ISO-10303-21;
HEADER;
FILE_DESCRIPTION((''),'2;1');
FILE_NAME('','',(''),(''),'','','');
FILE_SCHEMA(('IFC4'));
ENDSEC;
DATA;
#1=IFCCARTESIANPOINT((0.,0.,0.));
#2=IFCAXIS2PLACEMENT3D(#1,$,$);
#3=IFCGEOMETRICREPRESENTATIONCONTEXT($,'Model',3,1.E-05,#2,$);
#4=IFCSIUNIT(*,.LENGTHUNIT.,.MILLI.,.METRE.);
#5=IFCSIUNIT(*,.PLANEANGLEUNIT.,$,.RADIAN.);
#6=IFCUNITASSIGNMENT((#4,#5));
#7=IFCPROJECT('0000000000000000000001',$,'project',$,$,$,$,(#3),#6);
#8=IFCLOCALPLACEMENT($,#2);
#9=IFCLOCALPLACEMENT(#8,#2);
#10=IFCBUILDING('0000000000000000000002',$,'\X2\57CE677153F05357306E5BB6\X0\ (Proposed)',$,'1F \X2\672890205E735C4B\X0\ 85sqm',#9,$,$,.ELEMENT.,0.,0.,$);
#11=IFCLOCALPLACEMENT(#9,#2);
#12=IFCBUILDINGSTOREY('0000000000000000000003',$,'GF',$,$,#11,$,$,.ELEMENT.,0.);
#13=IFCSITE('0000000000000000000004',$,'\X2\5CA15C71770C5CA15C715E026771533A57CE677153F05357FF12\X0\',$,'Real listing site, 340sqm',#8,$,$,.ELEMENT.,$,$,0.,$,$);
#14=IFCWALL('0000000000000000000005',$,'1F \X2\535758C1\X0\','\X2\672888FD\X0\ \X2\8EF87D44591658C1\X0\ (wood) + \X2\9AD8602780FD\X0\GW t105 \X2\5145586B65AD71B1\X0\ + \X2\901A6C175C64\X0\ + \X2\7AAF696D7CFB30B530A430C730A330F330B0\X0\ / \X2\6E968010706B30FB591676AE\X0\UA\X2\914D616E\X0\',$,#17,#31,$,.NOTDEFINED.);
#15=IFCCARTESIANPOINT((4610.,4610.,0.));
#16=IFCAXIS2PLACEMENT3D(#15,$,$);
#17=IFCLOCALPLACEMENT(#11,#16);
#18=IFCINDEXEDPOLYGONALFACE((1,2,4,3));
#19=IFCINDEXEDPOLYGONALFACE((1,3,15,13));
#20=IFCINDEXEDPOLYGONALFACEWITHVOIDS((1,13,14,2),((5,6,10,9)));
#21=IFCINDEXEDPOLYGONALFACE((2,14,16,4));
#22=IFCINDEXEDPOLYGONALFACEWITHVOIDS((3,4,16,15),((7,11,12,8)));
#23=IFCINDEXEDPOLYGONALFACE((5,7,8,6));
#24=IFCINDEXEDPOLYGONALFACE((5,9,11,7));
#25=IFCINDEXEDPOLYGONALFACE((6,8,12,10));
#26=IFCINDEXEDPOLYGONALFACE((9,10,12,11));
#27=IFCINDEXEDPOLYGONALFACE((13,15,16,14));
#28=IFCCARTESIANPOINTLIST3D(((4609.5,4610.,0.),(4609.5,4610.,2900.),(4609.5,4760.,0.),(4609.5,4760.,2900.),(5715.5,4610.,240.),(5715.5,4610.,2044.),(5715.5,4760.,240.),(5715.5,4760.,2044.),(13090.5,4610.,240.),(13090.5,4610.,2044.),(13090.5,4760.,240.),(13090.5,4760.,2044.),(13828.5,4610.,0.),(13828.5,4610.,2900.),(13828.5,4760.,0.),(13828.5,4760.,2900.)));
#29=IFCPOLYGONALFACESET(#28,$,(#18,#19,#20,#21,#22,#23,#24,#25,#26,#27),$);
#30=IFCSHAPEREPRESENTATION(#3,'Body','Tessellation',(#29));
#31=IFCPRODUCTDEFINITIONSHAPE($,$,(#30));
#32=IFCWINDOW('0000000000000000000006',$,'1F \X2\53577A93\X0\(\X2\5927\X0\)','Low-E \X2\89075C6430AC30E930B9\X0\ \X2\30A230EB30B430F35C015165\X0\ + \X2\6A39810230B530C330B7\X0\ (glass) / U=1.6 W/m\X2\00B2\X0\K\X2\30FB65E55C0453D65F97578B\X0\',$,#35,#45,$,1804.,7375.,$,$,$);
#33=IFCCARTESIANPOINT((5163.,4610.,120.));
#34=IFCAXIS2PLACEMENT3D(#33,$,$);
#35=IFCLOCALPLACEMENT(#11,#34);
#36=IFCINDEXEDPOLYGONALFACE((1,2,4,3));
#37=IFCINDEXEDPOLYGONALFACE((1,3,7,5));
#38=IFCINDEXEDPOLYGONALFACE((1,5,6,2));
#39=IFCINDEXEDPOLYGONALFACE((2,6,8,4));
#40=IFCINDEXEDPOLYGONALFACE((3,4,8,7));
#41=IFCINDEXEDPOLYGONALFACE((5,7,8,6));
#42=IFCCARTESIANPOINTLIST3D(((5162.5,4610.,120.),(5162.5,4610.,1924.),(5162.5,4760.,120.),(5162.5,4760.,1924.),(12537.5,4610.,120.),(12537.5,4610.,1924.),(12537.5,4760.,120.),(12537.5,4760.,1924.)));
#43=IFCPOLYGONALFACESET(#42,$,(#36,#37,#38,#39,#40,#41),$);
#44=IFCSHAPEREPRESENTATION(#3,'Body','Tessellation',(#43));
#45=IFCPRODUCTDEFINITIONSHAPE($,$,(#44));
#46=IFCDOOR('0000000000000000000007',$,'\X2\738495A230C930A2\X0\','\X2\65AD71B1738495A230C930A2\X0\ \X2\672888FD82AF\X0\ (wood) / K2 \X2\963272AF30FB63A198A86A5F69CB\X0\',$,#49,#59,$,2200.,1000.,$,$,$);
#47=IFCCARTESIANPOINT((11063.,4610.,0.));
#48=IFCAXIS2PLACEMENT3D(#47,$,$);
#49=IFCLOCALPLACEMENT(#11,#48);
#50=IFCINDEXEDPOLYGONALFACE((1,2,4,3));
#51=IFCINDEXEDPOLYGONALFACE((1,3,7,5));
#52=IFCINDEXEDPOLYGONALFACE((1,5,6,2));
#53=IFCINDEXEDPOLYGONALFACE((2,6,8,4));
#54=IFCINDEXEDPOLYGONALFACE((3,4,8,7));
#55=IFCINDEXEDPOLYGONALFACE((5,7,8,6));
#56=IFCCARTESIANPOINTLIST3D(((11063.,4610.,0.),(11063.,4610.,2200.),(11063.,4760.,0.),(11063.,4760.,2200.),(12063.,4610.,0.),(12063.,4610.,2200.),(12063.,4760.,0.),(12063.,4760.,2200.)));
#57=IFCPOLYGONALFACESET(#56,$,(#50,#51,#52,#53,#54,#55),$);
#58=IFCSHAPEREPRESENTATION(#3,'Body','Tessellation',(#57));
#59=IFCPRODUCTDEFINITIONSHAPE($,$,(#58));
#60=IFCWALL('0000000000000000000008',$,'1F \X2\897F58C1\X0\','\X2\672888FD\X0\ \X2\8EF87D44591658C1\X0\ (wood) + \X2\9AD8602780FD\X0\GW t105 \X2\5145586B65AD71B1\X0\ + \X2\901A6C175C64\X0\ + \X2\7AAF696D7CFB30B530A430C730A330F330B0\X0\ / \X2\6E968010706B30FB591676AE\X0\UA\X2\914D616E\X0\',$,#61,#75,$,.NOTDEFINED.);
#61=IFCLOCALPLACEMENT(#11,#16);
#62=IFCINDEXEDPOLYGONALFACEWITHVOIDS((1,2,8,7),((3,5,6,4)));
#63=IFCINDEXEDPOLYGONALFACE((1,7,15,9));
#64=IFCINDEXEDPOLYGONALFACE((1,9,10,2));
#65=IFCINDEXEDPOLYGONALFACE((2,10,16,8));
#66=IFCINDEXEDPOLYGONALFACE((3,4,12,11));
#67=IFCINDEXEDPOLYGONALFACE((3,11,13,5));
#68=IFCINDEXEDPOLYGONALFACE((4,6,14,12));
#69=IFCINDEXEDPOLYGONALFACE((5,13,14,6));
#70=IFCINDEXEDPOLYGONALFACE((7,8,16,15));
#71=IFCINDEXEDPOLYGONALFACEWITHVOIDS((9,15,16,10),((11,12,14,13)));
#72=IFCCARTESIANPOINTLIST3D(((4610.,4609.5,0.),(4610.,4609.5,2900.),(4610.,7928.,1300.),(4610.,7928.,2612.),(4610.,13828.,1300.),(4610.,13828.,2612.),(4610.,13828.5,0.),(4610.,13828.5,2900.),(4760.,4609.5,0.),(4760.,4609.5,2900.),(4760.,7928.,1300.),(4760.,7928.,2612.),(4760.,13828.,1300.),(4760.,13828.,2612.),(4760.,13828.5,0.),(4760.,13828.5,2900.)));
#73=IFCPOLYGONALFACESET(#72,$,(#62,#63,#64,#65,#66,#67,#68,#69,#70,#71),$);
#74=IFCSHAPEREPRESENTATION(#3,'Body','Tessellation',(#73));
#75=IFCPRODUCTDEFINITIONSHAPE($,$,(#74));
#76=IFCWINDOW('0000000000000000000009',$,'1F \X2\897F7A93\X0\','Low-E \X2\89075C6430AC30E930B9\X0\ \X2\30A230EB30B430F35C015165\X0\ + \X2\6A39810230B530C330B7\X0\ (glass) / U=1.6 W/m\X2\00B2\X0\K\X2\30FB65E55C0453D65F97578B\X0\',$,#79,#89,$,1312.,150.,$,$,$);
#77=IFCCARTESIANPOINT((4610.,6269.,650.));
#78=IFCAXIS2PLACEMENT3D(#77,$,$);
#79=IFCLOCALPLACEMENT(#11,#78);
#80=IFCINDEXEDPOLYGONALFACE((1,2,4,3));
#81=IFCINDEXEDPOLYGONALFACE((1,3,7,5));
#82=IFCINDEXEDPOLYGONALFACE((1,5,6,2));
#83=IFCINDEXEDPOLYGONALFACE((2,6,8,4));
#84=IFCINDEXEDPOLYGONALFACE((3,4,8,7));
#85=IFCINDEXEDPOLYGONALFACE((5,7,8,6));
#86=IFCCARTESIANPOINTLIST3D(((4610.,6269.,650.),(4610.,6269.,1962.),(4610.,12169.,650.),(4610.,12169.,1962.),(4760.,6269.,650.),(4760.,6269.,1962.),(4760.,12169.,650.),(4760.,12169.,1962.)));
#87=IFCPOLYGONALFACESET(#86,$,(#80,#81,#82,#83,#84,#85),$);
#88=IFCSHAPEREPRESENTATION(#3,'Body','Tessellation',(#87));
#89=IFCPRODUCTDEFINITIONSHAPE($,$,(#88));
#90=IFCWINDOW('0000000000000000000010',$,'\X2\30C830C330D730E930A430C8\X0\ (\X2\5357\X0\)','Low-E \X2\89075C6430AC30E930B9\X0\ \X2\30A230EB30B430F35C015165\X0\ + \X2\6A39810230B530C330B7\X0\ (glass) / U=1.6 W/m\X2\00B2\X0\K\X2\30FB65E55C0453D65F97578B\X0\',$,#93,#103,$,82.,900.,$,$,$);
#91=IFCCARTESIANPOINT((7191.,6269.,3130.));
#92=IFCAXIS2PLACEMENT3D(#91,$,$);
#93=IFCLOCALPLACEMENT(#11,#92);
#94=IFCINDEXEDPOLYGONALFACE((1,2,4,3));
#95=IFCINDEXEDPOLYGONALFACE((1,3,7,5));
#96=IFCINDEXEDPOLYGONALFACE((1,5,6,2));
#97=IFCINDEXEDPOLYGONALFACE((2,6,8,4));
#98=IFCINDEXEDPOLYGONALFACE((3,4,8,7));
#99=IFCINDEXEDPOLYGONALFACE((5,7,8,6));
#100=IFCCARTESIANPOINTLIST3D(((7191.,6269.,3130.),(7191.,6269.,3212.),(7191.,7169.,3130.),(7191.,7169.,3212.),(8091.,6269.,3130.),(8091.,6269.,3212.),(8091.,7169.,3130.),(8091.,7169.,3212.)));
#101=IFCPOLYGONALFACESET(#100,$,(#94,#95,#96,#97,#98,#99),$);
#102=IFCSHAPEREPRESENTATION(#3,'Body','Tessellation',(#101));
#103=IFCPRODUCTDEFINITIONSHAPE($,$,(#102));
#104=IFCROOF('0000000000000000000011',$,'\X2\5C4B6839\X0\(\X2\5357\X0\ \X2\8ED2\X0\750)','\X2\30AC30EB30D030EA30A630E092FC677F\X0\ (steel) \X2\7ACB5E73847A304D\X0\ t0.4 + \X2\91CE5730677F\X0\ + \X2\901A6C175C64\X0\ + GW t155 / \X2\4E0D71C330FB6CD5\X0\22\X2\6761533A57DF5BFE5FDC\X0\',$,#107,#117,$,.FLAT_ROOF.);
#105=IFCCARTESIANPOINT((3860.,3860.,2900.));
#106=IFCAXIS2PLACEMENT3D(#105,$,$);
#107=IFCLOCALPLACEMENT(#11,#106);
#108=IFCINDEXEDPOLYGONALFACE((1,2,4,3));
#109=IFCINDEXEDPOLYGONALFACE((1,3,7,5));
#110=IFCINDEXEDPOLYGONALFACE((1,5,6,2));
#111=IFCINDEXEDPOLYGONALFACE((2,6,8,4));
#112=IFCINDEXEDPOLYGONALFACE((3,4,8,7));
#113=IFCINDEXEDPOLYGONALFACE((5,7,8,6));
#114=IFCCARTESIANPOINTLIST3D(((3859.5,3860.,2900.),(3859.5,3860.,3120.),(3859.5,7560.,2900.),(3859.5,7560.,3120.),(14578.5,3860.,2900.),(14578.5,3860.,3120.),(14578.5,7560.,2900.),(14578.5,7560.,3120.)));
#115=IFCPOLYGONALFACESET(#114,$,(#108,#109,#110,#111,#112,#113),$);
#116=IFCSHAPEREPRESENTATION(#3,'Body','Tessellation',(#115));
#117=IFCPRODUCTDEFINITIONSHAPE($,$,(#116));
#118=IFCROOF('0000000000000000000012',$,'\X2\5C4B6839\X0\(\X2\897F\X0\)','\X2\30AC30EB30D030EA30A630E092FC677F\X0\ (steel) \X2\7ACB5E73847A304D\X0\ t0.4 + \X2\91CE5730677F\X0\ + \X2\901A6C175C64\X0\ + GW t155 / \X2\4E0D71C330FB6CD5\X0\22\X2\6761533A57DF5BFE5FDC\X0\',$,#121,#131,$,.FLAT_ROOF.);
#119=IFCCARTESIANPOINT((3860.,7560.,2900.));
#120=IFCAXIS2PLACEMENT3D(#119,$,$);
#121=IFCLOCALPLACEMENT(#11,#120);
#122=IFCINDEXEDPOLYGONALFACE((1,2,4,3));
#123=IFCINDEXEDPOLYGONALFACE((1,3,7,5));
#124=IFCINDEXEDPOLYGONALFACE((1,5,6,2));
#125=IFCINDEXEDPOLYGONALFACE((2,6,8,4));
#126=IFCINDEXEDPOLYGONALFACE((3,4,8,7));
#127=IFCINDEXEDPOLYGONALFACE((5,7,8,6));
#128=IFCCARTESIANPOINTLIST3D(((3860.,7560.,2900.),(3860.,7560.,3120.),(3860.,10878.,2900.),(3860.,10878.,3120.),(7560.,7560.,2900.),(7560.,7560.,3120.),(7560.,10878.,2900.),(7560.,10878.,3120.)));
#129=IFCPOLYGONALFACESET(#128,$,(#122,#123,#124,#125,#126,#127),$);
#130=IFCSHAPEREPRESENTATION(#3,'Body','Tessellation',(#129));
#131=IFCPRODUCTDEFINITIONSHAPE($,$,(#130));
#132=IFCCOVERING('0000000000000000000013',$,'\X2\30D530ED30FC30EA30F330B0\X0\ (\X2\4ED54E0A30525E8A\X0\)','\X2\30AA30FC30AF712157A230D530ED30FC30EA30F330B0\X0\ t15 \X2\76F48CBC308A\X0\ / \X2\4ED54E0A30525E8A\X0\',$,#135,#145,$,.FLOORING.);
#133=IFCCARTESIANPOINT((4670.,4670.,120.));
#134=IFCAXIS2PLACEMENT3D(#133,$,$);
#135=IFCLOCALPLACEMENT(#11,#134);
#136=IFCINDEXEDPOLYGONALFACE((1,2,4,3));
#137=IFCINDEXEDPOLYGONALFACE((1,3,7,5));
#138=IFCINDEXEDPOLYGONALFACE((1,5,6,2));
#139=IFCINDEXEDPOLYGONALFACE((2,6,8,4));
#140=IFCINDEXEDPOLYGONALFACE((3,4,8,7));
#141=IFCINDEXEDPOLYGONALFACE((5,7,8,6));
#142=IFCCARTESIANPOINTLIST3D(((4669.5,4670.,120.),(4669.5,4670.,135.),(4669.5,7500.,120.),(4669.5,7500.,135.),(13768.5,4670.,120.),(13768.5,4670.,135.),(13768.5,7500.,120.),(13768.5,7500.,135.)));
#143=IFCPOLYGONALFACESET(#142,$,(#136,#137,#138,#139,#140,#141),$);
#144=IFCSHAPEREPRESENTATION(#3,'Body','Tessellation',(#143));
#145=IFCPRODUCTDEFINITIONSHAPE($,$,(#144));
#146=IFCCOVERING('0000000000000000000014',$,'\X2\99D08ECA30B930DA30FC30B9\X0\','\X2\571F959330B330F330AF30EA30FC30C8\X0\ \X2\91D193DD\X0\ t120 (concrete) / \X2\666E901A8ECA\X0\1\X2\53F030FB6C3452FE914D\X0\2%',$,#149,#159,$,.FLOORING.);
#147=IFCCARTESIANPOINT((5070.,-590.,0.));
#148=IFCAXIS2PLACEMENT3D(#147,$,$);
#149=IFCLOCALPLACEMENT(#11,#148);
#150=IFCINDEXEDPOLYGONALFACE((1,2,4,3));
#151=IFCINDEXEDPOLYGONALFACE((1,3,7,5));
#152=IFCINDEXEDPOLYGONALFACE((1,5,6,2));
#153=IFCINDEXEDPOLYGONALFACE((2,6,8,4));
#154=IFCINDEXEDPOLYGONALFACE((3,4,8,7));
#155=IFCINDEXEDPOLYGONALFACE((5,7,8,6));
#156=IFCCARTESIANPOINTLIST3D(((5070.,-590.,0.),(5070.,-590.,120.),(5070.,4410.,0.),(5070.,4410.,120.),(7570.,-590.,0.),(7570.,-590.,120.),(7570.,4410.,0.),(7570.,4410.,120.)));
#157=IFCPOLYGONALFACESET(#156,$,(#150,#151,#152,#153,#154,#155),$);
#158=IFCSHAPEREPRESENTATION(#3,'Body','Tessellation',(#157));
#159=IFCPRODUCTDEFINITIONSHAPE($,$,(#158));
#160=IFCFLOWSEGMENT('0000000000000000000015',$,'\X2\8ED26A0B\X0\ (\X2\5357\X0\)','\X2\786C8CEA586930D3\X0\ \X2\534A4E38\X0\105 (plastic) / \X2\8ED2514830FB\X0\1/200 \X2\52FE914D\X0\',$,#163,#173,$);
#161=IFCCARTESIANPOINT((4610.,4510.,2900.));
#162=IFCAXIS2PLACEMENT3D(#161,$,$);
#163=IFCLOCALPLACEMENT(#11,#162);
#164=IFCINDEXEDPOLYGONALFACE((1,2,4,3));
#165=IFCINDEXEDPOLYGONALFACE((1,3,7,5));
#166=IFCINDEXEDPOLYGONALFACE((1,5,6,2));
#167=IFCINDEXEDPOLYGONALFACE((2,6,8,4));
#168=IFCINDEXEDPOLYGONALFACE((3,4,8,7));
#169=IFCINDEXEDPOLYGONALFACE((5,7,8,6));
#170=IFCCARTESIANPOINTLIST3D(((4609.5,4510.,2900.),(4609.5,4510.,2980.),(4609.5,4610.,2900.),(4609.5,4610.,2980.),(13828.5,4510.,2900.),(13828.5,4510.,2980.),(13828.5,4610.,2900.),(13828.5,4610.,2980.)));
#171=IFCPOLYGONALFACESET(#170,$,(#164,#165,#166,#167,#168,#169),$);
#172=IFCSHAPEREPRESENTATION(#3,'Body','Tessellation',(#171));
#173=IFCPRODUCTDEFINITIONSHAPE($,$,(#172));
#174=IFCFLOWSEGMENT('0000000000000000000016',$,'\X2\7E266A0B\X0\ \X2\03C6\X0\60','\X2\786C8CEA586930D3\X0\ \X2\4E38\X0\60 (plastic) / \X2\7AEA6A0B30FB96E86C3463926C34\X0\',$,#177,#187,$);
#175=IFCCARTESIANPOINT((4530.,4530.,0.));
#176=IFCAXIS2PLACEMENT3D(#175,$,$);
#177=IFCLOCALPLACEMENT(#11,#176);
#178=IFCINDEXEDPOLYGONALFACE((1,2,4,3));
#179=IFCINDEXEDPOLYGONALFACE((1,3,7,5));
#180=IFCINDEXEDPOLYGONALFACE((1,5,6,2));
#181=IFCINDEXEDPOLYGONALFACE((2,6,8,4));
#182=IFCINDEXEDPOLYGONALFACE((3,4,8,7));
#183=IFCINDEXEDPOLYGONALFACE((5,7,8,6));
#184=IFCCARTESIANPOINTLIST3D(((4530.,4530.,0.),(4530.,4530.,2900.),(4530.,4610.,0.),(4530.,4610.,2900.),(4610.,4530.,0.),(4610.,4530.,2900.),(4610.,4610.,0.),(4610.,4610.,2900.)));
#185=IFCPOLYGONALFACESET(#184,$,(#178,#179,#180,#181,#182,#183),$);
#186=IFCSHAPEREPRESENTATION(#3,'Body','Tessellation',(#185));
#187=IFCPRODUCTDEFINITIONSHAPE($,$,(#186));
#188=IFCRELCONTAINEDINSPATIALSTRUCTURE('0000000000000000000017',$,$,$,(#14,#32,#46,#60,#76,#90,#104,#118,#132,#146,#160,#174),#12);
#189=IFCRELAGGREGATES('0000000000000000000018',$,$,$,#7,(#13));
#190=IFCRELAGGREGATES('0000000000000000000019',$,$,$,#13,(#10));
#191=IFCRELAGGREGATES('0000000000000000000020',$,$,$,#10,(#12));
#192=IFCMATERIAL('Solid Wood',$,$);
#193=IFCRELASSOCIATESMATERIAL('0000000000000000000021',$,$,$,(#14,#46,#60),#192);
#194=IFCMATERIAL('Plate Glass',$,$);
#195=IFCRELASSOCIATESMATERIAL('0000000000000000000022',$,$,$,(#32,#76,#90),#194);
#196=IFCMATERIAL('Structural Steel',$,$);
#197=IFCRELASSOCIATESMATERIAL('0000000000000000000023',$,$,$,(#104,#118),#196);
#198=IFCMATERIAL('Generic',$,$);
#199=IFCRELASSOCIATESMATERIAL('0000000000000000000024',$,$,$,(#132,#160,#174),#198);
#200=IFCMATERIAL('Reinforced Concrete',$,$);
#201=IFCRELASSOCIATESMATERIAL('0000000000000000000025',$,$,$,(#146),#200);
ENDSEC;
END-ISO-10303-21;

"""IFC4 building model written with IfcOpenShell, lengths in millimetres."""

from ifc_helpers import new_model, si_unit, frame, frame_2d, origin, place, context, project, spatial, rectangle, extrude, material, element, fill, save


model = new_model("IFC4")

# Units and contexts
model_context = context("Model", 3, precision=1e-05, world=origin())
ifc_project = project(units=[si_unit("LENGTHUNIT", "METRE", prefix="MILLI"), si_unit("PLANEANGLEUNIT", "RADIAN")], contexts=[model_context])

# Site, building, storey
site_placement = place(None, origin())
site = spatial("IfcSite", under=ifc_project, at=site_placement, Name="岡山県岡山市東区城東台南２", ObjectType="Real listing site, 340sqm", CompositionType="ELEMENT", RefElevation=0.0)
building_placement = place(site_placement, origin())
building = spatial("IfcBuilding", under=site, at=building_placement, Name="城東台南の家 (Proposed)", ObjectType="1F 木造平屋 85sqm", CompositionType="ELEMENT", ElevationOfRefHeight=0.0, ElevationOfTerrain=0.0)
storey_placement = place(building_placement, origin())
storey = spatial("IfcBuildingStorey", under=building, at=storey_placement, Name="GF", CompositionType="ELEMENT", Elevation=0.0)

# Shared definitions
ifc_material_1 = material(Name="Solid Wood")

# Shared definitions
ifc_material_2 = material(Name="Reinforced Concrete")

# Wall, openings, window, door
wall_1_placement = place(storey_placement, frame((4610.0, 4610.0, 0.0)))
wall_1 = element("IfcWall", 1, at=wall_1_placement, inside=storey, material=ifc_material_1, Name="1F 南壁", Description="木製 軸組外壁 (wood) + 高性能GW t105 充填断熱 + 通気層 + 窯業系サイディング / 準耐火・外皮UA配慮", PredefinedType="NOTDEFINED", context=model_context, shape_type="SweptSolid", body=[
    extrude(rectangle(XDim=9219.0, YDim=150.0, at=frame_2d((4609.0, 75.0))), frame((4610.0, 4610.0, 0.0)), (0.0, 0.0, 1.0), 2900.0),
])
opening_1_placement = place(storey_placement, frame((5163.0, 4610.0, 120.0)))
opening_1 = element("IfcOpeningElement", 2, at=opening_1_placement, cuts=wall_1, PredefinedType="NOTDEFINED", context=model_context, shape_type="SweptSolid", body=[
    extrude(rectangle(XDim=7375.0, YDim=150.0, at=frame_2d((3687.0, 75.0))), frame((5163.0, 4610.0, 120.0)), (0.0, 0.0, 1.0), 1804.0),
])
opening_2_placement = place(storey_placement, frame((11063.0, 4610.0, 0.0)))
opening_2 = element("IfcOpeningElement", 3, at=opening_2_placement, cuts=wall_1, PredefinedType="NOTDEFINED", context=model_context, shape_type="SweptSolid", body=[
    extrude(rectangle(XDim=1000.0, YDim=150.0, at=frame_2d((500.0, 75.0))), frame((11063.0, 4610.0, 0.0)), (0.0, 0.0, 1.0), 2200.0),
])
ifc_material_3 = material(Name="Plate Glass")
window_1_placement = place(storey_placement, frame((5163.0, 4610.0, 120.0)))
window_1 = element("IfcWindow", 4, at=window_1_placement, inside=storey, material=ifc_material_3, Name="1F 南窓(大)", Description="Low-E 複層ガラス アルゴン封入 + 樹脂サッシ (glass) / U=1.6 W/m²K・日射取得型", OverallHeight=1804.0, OverallWidth=7375.0, context=model_context, shape_type="SweptSolid", body=[
    extrude(rectangle(XDim=7375.0, YDim=150.0, at=frame_2d((3687.0, 75.0))), frame((5163.0, 4610.0, 120.0)), (0.0, 0.0, 1.0), 1804.0),
])
fill(opening_1, window_1)
door_placement = place(storey_placement, frame((11063.0, 4610.0, 0.0)))
door = element("IfcDoor", 5, at=door_placement, inside=storey, material=ifc_material_1, Name="玄関ドア", Description="断熱玄関ドア 木製芯 (wood) / K2 防犯・採風機構", OverallHeight=2200.0, OverallWidth=1000.0, context=model_context, shape_type="SweptSolid", body=[
    extrude(rectangle(XDim=1000.0, YDim=150.0, at=frame_2d((500.0, 75.0))), frame((11063.0, 4610.0, 0.0)), (0.0, 0.0, 1.0), 2200.0),
])
fill(opening_2, door)

# Wall, opening, window
wall_2_placement = place(storey_placement, frame((4610.0, 4610.0, 0.0)))
wall_2 = element("IfcWall", 6, at=wall_2_placement, inside=storey, material=ifc_material_1, Name="1F 西壁", Description="木製 軸組外壁 (wood) + 高性能GW t105 充填断熱 + 通気層 + 窯業系サイディング / 準耐火・外皮UA配慮", PredefinedType="NOTDEFINED", context=model_context, shape_type="SweptSolid", body=[
    extrude(rectangle(XDim=150.0, YDim=9219.0, at=frame_2d((75.0, 4609.0))), frame((4610.0, 4610.0, 0.0)), (0.0, 0.0, 1.0), 2900.0),
])
opening_3_placement = place(storey_placement, frame((4610.0, 6269.0, 650.0)))
opening_3 = element("IfcOpeningElement", 7, at=opening_3_placement, cuts=wall_2, PredefinedType="NOTDEFINED", context=model_context, shape_type="SweptSolid", body=[
    extrude(rectangle(XDim=150.0, YDim=5900.0, at=frame_2d((75.0, 2950.0))), frame((4610.0, 6269.0, 650.0)), (0.0, 0.0, 1.0), 1312.0),
])
window_2_placement = place(storey_placement, frame((4610.0, 6269.0, 650.0)))
window_2 = element("IfcWindow", 8, at=window_2_placement, inside=storey, material=ifc_material_3, Name="1F 西窓", Description="Low-E 複層ガラス アルゴン封入 + 樹脂サッシ (glass) / U=1.6 W/m²K・日射取得型", OverallHeight=1312.0, OverallWidth=150.0, context=model_context, shape_type="SweptSolid", body=[
    extrude(rectangle(XDim=150.0, YDim=5900.0, at=frame_2d((75.0, 2950.0))), frame((4610.0, 6269.0, 650.0)), (0.0, 0.0, 1.0), 1312.0),
])
fill(opening_3, window_2)

# Window
window_3_placement = place(storey_placement, frame((7191.0, 6269.0, 3130.0)))
element("IfcWindow", 9, at=window_3_placement, inside=storey, material=ifc_material_3, Name="トップライト (南)", Description="Low-E 複層ガラス アルゴン封入 + 樹脂サッシ (glass) / U=1.6 W/m²K・日射取得型", OverallHeight=82.0, OverallWidth=900.0, context=model_context, shape_type="SweptSolid", body=[
    extrude(rectangle(XDim=900.0, YDim=900.0, at=frame_2d((450.0, 450.0))), frame((7191.0, 6269.0, 3130.0)), (0.0, 0.0, 1.0), 82.0),
])

# Roofs
ifc_material_4 = material(Name="Structural Steel")
roof_1_placement = place(storey_placement, frame((3860.0, 3860.0, 2900.0)))
element("IfcRoof", 10, at=roof_1_placement, inside=storey, material=ifc_material_4, Name="屋根(南 軒750)", Description="ガルバリウム鋼板 (steel) 立平葺き t0.4 + 野地板 + 通気層 + GW t155 / 不燃・法22条区域対応", PredefinedType="FLAT_ROOF", context=model_context, shape_type="SweptSolid", body=[
    extrude(rectangle(XDim=10719.0, YDim=3700.0, at=frame_2d((5359.0, 1850.0))), frame((3860.0, 3860.0, 2900.0)), (0.0, 0.0, 1.0), 220.0),
])
roof_2_placement = place(storey_placement, frame((3860.0, 7560.0, 2900.0)))
element("IfcRoof", 11, at=roof_2_placement, inside=storey, material=ifc_material_4, Name="屋根(西)", Description="ガルバリウム鋼板 (steel) 立平葺き t0.4 + 野地板 + 通気層 + GW t155 / 不燃・法22条区域対応", PredefinedType="FLAT_ROOF", context=model_context, shape_type="SweptSolid", body=[
    extrude(rectangle(XDim=3700.0, YDim=3318.0, at=frame_2d((1850.0, 1659.0))), frame((3860.0, 7560.0, 2900.0)), (0.0, 0.0, 1.0), 220.0),
])

# Coverings
ifc_material_5 = material(Name="Generic")
covering_1_placement = place(storey_placement, frame((4670.0, 4670.0, 120.0)))
element("IfcCovering", 12, at=covering_1_placement, inside=storey, material=ifc_material_5, Name="フローリング (仕上げ床)", Description="オーク無垢フローリング t15 直貼り / 仕上げ床", PredefinedType="FLOORING", context=model_context, shape_type="SweptSolid", body=[
    extrude(rectangle(XDim=9099.0, YDim=2830.0, at=frame_2d((4549.0, 1415.0))), frame((4670.0, 4670.0, 120.0)), (0.0, 0.0, 1.0), 15.0),
])
covering_2_placement = place(storey_placement, frame((5070.0, -590.0, 0.0)))
element("IfcCovering", 13, at=covering_2_placement, inside=storey, material=ifc_material_2, Name="駐車スペース", Description="土間コンクリート 金鏝 t120 (concrete) / 普通車1台・水勾配2%", PredefinedType="FLOORING", context=model_context, shape_type="SweptSolid", body=[
    extrude(rectangle(XDim=2500.0, YDim=5000.0, at=frame_2d((1250.0, 2500.0))), frame((5070.0, -590.0, 0.0)), (0.0, 0.0, 1.0), 120.0),
])

# Flow segments
flow_segment_1_placement = place(storey_placement, frame((4610.0, 4510.0, 2900.0)))
element("IfcFlowSegment", 14, at=flow_segment_1_placement, inside=storey, material=ifc_material_5, Name="軒樋 (南)", Description="硬質塩ビ 半丸105 (plastic) / 軒先・1/200 勾配", context=model_context, shape_type="SweptSolid", body=[
    extrude(rectangle(XDim=9219.0, YDim=100.0, at=frame_2d((4609.0, 50.0))), frame((4610.0, 4510.0, 2900.0)), (0.0, 0.0, 1.0), 80.0),
])
flow_segment_2_placement = place(storey_placement, frame((4530.0, 4530.0, 0.0)))
element("IfcFlowSegment", 15, at=flow_segment_2_placement, inside=storey, material=ifc_material_5, Name="縦樋 φ60", Description="硬質塩ビ 丸60 (plastic) / 竪樋・雨水排水", context=model_context, shape_type="SweptSolid", body=[
    extrude(rectangle(XDim=80.0, YDim=80.0, at=frame_2d((40.0, 40.0))), frame((4530.0, 4530.0, 0.0)), (0.0, 0.0, 1.0), 2900.0),
])

save(model, "model.ifc")
